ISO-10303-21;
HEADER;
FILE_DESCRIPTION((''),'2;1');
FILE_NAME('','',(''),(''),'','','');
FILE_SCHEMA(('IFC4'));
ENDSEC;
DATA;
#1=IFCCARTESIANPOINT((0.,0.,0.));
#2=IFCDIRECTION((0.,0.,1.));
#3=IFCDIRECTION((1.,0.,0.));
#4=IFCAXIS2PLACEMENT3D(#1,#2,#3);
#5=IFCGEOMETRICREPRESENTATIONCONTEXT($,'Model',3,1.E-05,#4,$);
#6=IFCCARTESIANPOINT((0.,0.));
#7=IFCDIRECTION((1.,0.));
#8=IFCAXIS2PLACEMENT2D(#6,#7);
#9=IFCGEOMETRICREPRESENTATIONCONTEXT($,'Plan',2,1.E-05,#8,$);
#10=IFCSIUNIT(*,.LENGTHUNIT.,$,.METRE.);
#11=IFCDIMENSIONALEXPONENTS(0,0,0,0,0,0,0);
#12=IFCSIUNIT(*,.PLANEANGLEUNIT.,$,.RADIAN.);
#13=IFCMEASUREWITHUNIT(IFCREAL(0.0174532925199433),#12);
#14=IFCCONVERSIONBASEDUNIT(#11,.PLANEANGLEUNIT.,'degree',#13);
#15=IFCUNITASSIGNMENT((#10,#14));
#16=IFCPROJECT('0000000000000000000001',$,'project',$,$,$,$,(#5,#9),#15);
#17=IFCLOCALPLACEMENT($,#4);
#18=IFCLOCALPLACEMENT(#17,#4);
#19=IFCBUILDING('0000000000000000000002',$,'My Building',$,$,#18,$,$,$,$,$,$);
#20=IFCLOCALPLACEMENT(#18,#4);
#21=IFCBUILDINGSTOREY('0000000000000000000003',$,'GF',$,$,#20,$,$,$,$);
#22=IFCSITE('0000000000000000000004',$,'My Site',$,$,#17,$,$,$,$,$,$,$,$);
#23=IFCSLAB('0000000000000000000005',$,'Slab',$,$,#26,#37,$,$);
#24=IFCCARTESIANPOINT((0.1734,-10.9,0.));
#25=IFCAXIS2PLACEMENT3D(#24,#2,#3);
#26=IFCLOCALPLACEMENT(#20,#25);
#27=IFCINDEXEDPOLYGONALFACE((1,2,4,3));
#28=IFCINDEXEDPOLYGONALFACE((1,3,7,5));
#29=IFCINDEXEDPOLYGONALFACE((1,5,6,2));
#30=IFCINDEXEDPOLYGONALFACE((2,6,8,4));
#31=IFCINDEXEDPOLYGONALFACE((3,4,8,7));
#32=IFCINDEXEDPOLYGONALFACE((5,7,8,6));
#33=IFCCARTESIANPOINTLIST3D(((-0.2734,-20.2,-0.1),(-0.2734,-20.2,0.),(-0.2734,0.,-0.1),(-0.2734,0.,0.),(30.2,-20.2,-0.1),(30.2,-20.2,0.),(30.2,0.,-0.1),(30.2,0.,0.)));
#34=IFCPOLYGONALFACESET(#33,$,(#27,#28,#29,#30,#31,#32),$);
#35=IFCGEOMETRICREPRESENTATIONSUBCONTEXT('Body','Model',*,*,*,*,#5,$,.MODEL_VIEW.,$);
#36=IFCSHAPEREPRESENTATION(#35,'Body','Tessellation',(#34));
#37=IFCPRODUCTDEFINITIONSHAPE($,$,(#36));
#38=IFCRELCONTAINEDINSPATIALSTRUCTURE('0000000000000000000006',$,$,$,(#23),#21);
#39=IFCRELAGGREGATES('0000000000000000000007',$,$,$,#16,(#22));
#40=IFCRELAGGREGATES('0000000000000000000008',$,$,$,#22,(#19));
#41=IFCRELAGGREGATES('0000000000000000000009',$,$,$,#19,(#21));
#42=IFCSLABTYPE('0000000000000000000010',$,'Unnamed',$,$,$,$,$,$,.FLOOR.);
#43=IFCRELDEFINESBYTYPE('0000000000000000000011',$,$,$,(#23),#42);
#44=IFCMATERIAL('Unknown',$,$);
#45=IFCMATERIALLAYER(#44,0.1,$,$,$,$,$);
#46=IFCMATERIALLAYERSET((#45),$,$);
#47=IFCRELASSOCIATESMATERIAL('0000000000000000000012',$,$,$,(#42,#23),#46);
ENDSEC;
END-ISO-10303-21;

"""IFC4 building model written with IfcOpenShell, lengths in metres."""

from ifc_helpers import new_model, entity, si_unit, converted_unit, frame, origin_with_axes, origin_2d_with_axis, place, context, subcontext, project, spatial, indexed_curve, outline, extrude, material, layer, layer_set, layer_usage, type_object, element, save


model = new_model("IFC4")

# Units and contexts
model_context = context("Model", 3, precision=1e-05, world=origin_with_axes())
plan_context = context("Plan", 2, precision=1e-05, world=origin_2d_with_axis())
body_context_1 = subcontext(model_context, "Body", "Model", "MODEL_VIEW")
ifc_project = project(units=[si_unit("LENGTHUNIT", "METRE"), converted_unit("PLANEANGLEUNIT", "degree", entity("IfcReal", 0.0174532925199433), si_unit("PLANEANGLEUNIT", "RADIAN"), dimensions=[0, 0, 0, 0, 0, 0, 0])], contexts=[model_context, plan_context])

# Site, building, storey
site_placement = place(None, origin_with_axes())
site = spatial("IfcSite", under=ifc_project, at=site_placement, Name="My Site")
building_placement = place(site_placement, origin_with_axes())
building = spatial("IfcBuilding", under=site, at=building_placement, Name="My Building")
storey_placement = place(building_placement, origin_with_axes())
storey = spatial("IfcBuildingStorey", under=building, at=storey_placement, Name="GF")

# Slab
ifc_material = material(Name="Unknown")
ifc_layer_1 = layer(ifc_material, 0.1)
ifc_layer_set_1 = layer_set([ifc_layer_1])
ifc_layer_usage_1 = layer_usage(ifc_layer_set_1, "AXIS3", "POSITIVE", -0.1)
slab_type = type_object("IfcSlabType", Name="Unnamed", PredefinedType="FLOOR", material=ifc_layer_set_1)
slab_placement = place(storey_placement, frame((0.1734, -10.9, 0.0), z_axis=(0.0, 0.0, 1.0), x_axis=(1.0, 0.0, 0.0)))
element("IfcSlab", 1, at=slab_placement, inside=storey, type_object=slab_type, material=ifc_layer_usage_1, Name="Slab", context=body_context_1, shape_type="SweptSolid", body=[
    extrude(outline(indexed_curve([(-0.2734, -20.2), (30.2, -20.2), (30.2, 0.0), (-0.2734, 0.0), (-0.2734, -20.2)])), frame((0.0, 0.0, -0.1), z_axis=(0.0, 0.0, 1.0), x_axis=(1.0, 0.0, 0.0)), (0.0, 0.0, 1.0), 0.1),
])

save(model, "model.ifc")
